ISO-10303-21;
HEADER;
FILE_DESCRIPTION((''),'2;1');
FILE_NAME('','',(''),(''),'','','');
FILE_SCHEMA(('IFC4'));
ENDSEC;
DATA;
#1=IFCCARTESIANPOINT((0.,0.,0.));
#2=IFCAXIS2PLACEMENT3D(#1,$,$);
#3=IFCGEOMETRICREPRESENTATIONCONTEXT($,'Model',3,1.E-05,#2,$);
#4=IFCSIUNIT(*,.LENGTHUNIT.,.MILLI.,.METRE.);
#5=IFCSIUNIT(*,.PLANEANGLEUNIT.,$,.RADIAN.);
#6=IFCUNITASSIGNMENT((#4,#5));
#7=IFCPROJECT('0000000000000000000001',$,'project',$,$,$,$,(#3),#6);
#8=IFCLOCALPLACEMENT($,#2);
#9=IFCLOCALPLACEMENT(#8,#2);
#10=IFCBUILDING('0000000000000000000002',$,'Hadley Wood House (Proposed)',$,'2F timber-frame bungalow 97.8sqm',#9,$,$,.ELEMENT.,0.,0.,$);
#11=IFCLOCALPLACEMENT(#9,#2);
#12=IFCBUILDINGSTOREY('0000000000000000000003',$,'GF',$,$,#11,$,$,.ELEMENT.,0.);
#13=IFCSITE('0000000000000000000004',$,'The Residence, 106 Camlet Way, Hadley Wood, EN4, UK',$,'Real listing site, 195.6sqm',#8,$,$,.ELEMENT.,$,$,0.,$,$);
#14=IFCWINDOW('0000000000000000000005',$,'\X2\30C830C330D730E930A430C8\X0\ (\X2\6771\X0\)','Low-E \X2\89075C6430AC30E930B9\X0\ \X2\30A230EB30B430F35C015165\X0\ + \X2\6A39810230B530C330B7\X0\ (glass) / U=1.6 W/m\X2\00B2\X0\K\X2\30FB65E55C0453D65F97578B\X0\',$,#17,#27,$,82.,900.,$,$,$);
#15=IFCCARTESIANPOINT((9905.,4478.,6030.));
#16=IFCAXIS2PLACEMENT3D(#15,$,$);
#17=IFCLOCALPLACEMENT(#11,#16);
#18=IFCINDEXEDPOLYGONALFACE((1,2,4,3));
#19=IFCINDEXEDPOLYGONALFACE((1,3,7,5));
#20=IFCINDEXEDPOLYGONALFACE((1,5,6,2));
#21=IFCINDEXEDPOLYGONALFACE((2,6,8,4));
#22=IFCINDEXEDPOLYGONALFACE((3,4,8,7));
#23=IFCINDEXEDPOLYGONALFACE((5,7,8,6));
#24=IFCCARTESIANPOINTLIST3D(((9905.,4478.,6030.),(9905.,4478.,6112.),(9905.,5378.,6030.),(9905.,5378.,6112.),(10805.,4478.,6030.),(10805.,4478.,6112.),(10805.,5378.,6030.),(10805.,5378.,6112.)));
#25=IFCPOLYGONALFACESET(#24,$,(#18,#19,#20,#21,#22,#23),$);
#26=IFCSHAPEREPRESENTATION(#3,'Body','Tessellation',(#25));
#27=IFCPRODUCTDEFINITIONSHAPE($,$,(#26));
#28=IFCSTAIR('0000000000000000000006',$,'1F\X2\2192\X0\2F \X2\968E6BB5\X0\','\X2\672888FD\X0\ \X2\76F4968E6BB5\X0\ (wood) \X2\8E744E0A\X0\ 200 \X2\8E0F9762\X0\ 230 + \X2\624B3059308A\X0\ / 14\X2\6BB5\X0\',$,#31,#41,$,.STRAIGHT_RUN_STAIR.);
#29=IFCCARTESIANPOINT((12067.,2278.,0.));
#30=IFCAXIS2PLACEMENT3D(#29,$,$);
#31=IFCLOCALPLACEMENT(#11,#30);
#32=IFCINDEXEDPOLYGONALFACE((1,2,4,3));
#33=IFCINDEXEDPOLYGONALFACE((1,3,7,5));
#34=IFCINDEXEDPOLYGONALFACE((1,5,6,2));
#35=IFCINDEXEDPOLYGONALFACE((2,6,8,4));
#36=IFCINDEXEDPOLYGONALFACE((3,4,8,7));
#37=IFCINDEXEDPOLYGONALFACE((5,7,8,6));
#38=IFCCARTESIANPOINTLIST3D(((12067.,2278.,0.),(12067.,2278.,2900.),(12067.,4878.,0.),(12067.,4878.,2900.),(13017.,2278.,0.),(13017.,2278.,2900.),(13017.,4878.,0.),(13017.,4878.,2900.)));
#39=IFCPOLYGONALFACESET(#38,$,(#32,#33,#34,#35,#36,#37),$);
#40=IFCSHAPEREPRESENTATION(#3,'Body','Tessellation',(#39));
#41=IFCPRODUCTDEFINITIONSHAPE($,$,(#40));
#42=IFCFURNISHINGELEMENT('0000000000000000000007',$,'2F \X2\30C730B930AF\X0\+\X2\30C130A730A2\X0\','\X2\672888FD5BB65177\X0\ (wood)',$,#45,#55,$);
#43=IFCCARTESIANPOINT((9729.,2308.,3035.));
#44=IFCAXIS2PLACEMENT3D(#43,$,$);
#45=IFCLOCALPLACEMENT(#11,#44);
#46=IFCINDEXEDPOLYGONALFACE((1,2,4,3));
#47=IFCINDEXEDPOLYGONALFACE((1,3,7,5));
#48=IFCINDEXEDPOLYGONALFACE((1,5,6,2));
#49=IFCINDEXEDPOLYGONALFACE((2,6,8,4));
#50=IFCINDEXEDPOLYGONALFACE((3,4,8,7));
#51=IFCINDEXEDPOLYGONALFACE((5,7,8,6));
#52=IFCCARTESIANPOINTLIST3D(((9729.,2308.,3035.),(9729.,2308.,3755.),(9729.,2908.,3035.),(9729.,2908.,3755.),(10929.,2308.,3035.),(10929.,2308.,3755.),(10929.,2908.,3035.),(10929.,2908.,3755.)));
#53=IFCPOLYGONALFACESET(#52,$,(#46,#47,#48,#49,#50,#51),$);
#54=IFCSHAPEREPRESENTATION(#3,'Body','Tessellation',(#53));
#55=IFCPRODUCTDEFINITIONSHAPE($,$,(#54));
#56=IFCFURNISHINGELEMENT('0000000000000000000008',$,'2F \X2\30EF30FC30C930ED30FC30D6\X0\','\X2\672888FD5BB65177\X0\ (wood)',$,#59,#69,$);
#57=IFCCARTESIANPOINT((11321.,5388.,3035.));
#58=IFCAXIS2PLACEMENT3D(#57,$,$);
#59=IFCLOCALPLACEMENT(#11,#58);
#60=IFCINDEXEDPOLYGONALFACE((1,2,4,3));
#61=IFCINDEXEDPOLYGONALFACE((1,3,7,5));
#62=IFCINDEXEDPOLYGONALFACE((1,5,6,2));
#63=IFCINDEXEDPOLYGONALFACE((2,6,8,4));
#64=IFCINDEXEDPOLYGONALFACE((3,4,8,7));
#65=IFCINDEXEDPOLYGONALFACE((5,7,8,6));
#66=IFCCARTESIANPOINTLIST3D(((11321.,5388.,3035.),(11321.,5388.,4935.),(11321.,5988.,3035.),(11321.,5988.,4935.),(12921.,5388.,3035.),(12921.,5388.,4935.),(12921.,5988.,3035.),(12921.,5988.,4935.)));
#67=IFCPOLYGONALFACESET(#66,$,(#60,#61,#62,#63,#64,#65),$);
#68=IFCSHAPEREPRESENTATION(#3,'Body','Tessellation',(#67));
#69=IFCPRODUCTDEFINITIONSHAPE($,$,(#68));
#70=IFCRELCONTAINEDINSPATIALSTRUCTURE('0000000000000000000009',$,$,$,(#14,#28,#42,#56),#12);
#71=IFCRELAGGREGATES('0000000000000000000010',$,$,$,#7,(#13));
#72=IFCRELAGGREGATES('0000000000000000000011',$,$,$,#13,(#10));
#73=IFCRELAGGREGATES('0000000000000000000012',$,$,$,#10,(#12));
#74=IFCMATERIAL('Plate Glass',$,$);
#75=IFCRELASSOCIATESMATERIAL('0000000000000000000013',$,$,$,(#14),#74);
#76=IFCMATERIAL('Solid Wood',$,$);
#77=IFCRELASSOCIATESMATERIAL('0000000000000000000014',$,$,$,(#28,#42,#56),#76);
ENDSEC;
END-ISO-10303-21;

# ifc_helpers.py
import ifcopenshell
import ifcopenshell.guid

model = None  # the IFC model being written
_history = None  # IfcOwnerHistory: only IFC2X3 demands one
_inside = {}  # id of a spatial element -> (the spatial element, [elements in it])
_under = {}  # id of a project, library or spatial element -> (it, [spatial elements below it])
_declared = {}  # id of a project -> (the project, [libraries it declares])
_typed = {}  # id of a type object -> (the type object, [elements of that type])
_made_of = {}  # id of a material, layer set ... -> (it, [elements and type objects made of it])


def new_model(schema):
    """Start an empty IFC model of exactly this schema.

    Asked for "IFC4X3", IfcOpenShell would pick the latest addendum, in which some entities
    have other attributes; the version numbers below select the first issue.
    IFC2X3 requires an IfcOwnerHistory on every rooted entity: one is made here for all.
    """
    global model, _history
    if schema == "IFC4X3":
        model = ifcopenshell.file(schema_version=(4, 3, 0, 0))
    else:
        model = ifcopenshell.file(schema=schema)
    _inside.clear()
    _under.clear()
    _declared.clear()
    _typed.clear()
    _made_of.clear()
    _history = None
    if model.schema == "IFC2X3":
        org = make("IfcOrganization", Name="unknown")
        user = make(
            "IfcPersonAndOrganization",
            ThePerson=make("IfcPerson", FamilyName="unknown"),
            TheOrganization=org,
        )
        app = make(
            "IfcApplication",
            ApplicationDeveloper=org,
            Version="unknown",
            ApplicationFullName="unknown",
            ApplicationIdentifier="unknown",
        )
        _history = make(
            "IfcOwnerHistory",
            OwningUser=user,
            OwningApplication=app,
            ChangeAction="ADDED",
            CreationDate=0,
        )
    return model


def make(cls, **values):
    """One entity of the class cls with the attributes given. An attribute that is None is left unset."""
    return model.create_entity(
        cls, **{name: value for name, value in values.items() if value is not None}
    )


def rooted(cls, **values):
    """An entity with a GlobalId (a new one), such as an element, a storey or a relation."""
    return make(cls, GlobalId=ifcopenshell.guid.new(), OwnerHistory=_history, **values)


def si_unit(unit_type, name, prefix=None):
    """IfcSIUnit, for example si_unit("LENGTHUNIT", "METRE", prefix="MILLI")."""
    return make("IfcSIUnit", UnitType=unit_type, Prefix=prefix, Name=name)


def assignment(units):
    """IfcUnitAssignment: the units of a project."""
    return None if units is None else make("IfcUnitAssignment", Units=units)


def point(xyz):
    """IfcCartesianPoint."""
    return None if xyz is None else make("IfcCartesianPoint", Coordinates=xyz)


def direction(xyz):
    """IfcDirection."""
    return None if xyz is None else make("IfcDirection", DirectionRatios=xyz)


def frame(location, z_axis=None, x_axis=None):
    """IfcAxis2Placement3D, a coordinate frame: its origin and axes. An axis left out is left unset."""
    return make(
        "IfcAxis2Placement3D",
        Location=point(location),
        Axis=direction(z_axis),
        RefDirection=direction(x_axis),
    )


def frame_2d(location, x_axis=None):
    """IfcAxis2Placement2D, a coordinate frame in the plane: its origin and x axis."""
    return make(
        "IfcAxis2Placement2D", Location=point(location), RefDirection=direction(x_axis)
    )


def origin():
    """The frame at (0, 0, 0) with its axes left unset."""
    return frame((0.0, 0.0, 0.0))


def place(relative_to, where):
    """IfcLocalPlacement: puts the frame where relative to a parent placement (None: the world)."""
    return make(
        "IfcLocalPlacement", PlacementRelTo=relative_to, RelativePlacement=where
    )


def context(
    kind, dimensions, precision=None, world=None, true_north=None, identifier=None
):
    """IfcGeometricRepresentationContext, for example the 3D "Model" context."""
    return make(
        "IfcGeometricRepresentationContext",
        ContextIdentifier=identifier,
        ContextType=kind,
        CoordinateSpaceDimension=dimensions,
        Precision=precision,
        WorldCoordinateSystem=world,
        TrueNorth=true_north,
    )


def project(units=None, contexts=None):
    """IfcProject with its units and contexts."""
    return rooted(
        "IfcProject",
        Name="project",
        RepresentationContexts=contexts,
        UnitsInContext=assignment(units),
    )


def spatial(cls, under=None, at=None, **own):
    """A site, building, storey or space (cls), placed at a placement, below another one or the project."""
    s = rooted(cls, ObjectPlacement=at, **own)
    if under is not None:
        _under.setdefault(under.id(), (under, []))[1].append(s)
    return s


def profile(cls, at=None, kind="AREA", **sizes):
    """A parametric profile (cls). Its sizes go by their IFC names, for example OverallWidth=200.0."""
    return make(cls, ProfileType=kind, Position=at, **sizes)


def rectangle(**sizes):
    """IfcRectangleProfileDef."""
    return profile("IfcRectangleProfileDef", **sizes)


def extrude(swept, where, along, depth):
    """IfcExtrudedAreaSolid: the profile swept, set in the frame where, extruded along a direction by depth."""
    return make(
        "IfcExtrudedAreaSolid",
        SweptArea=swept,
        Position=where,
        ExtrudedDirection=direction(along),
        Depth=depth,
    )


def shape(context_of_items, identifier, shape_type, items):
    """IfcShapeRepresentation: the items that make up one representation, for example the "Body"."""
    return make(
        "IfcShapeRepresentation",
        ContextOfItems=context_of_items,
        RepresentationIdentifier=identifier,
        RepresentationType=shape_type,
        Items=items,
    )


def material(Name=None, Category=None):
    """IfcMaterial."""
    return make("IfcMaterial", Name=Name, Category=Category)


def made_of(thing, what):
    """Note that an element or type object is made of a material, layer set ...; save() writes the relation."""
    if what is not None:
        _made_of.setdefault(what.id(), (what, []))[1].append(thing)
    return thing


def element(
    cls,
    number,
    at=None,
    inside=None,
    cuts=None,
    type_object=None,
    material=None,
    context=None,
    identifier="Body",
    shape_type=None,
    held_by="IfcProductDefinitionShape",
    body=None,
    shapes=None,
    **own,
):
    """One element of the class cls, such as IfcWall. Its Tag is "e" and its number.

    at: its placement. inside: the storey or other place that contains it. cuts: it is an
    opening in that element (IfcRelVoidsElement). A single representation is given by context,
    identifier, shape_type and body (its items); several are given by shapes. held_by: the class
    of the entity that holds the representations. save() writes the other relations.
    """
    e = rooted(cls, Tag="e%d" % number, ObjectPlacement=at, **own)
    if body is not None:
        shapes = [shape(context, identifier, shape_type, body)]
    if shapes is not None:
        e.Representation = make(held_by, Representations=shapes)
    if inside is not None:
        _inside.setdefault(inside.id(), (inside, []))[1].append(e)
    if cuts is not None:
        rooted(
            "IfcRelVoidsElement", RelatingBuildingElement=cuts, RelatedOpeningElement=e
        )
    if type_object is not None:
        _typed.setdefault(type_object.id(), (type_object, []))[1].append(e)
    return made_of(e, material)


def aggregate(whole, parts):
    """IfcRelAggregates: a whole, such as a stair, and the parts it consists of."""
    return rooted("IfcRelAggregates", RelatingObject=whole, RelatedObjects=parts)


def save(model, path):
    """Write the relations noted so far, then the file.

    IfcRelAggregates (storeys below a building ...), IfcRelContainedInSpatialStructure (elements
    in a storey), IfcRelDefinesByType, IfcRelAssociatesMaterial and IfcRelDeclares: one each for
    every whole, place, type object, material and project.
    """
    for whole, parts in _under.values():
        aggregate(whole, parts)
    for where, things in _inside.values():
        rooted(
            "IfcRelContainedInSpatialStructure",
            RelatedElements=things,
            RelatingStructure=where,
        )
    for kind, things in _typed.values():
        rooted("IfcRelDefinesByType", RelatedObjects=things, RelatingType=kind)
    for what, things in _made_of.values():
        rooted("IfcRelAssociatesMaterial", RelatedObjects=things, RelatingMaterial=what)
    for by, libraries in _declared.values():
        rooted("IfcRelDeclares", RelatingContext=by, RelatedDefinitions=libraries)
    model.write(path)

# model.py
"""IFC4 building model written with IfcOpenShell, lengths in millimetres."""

from ifc_helpers import new_model, si_unit, frame, frame_2d, origin, place, context, project, spatial, rectangle, extrude, material, element, save


model = new_model("IFC4")

# Units and contexts
model_context = context("Model", 3, precision=1e-05, world=origin())
ifc_project = project(units=[si_unit("LENGTHUNIT", "METRE", prefix="MILLI"), si_unit("PLANEANGLEUNIT", "RADIAN")], contexts=[model_context])

# Site, building, storey
site_placement = place(None, origin())
site = spatial("IfcSite", under=ifc_project, at=site_placement, Name="The Residence, 106 Camlet Way, Hadley Wood, EN4, UK", ObjectType="Real listing site, 195.6sqm", CompositionType="ELEMENT", RefElevation=0.0)
building_placement = place(site_placement, origin())
building = spatial("IfcBuilding", under=site, at=building_placement, Name="Hadley Wood House (Proposed)", ObjectType="2F timber-frame bungalow 97.8sqm", CompositionType="ELEMENT", ElevationOfRefHeight=0.0, ElevationOfTerrain=0.0)
storey_placement = place(building_placement, origin())
storey = spatial("IfcBuildingStorey", under=building, at=storey_placement, Name="GF", CompositionType="ELEMENT", Elevation=0.0)

# Shared definitions
ifc_material_1 = material(Name="Solid Wood")

# Shared definitions
ifc_material_2 = material(Name="Plate Glass")

# Window
window_1_placement = place(storey_placement, frame((9905.0, 4478.0, 6030.0)))
element("IfcWindow", 1, at=window_1_placement, inside=storey, material=ifc_material_2, Name="トップライト (東)", Description="Low-E 複層ガラス アルゴン封入 + 樹脂サッシ (glass) / U=1.6 W/m²K・日射取得型", OverallHeight=82.0, OverallWidth=900.0, context=model_context, shape_type="SweptSolid", body=[
    extrude(rectangle(XDim=900.0, YDim=900.0, at=frame_2d((450.0, 450.0))), frame((9905.0, 4478.0, 6030.0)), (0.0, 0.0, 1.0), 82.0),
])

# Stair
stair_placement = place(storey_placement, frame((12067.0, 2278.0, 0.0)))
element("IfcStair", 2, at=stair_placement, inside=storey, material=ifc_material_1, Name="1F→2F 階段", Description="木製 直階段 (wood) 蹴上 200 踏面 230 + 手すり / 14段", PredefinedType="STRAIGHT_RUN_STAIR", context=model_context, shape_type="SweptSolid", body=[
    extrude(rectangle(XDim=950.0, YDim=2600.0, at=frame_2d((475.0, 1300.0))), frame((12067.0, 2278.0, 0.0)), (0.0, 0.0, 1.0), 2900.0),
])

# Furnishing elements
furnishing_1_placement = place(storey_placement, frame((9729.0, 2308.0, 3035.0)))
element("IfcFurnishingElement", 3, at=furnishing_1_placement, inside=storey, material=ifc_material_1, Name="2F デスク+チェア", Description="木製家具 (wood)", context=model_context, shape_type="SweptSolid", body=[
    extrude(rectangle(XDim=1200.0, YDim=600.0, at=frame_2d((600.0, 300.0))), frame((9729.0, 2308.0, 3035.0)), (0.0, 0.0, 1.0), 720.0),
])
furnishing_2_placement = place(storey_placement, frame((11321.0, 5388.0, 3035.0)))
element("IfcFurnishingElement", 4, at=furnishing_2_placement, inside=storey, material=ifc_material_1, Name="2F ワードローブ", Description="木製家具 (wood)", context=model_context, shape_type="SweptSolid", body=[
    extrude(rectangle(XDim=1600.0, YDim=600.0, at=frame_2d((800.0, 300.0))), frame((11321.0, 5388.0, 3035.0)), (0.0, 0.0, 1.0), 1900.0),
])

save(model, "model.ifc")
